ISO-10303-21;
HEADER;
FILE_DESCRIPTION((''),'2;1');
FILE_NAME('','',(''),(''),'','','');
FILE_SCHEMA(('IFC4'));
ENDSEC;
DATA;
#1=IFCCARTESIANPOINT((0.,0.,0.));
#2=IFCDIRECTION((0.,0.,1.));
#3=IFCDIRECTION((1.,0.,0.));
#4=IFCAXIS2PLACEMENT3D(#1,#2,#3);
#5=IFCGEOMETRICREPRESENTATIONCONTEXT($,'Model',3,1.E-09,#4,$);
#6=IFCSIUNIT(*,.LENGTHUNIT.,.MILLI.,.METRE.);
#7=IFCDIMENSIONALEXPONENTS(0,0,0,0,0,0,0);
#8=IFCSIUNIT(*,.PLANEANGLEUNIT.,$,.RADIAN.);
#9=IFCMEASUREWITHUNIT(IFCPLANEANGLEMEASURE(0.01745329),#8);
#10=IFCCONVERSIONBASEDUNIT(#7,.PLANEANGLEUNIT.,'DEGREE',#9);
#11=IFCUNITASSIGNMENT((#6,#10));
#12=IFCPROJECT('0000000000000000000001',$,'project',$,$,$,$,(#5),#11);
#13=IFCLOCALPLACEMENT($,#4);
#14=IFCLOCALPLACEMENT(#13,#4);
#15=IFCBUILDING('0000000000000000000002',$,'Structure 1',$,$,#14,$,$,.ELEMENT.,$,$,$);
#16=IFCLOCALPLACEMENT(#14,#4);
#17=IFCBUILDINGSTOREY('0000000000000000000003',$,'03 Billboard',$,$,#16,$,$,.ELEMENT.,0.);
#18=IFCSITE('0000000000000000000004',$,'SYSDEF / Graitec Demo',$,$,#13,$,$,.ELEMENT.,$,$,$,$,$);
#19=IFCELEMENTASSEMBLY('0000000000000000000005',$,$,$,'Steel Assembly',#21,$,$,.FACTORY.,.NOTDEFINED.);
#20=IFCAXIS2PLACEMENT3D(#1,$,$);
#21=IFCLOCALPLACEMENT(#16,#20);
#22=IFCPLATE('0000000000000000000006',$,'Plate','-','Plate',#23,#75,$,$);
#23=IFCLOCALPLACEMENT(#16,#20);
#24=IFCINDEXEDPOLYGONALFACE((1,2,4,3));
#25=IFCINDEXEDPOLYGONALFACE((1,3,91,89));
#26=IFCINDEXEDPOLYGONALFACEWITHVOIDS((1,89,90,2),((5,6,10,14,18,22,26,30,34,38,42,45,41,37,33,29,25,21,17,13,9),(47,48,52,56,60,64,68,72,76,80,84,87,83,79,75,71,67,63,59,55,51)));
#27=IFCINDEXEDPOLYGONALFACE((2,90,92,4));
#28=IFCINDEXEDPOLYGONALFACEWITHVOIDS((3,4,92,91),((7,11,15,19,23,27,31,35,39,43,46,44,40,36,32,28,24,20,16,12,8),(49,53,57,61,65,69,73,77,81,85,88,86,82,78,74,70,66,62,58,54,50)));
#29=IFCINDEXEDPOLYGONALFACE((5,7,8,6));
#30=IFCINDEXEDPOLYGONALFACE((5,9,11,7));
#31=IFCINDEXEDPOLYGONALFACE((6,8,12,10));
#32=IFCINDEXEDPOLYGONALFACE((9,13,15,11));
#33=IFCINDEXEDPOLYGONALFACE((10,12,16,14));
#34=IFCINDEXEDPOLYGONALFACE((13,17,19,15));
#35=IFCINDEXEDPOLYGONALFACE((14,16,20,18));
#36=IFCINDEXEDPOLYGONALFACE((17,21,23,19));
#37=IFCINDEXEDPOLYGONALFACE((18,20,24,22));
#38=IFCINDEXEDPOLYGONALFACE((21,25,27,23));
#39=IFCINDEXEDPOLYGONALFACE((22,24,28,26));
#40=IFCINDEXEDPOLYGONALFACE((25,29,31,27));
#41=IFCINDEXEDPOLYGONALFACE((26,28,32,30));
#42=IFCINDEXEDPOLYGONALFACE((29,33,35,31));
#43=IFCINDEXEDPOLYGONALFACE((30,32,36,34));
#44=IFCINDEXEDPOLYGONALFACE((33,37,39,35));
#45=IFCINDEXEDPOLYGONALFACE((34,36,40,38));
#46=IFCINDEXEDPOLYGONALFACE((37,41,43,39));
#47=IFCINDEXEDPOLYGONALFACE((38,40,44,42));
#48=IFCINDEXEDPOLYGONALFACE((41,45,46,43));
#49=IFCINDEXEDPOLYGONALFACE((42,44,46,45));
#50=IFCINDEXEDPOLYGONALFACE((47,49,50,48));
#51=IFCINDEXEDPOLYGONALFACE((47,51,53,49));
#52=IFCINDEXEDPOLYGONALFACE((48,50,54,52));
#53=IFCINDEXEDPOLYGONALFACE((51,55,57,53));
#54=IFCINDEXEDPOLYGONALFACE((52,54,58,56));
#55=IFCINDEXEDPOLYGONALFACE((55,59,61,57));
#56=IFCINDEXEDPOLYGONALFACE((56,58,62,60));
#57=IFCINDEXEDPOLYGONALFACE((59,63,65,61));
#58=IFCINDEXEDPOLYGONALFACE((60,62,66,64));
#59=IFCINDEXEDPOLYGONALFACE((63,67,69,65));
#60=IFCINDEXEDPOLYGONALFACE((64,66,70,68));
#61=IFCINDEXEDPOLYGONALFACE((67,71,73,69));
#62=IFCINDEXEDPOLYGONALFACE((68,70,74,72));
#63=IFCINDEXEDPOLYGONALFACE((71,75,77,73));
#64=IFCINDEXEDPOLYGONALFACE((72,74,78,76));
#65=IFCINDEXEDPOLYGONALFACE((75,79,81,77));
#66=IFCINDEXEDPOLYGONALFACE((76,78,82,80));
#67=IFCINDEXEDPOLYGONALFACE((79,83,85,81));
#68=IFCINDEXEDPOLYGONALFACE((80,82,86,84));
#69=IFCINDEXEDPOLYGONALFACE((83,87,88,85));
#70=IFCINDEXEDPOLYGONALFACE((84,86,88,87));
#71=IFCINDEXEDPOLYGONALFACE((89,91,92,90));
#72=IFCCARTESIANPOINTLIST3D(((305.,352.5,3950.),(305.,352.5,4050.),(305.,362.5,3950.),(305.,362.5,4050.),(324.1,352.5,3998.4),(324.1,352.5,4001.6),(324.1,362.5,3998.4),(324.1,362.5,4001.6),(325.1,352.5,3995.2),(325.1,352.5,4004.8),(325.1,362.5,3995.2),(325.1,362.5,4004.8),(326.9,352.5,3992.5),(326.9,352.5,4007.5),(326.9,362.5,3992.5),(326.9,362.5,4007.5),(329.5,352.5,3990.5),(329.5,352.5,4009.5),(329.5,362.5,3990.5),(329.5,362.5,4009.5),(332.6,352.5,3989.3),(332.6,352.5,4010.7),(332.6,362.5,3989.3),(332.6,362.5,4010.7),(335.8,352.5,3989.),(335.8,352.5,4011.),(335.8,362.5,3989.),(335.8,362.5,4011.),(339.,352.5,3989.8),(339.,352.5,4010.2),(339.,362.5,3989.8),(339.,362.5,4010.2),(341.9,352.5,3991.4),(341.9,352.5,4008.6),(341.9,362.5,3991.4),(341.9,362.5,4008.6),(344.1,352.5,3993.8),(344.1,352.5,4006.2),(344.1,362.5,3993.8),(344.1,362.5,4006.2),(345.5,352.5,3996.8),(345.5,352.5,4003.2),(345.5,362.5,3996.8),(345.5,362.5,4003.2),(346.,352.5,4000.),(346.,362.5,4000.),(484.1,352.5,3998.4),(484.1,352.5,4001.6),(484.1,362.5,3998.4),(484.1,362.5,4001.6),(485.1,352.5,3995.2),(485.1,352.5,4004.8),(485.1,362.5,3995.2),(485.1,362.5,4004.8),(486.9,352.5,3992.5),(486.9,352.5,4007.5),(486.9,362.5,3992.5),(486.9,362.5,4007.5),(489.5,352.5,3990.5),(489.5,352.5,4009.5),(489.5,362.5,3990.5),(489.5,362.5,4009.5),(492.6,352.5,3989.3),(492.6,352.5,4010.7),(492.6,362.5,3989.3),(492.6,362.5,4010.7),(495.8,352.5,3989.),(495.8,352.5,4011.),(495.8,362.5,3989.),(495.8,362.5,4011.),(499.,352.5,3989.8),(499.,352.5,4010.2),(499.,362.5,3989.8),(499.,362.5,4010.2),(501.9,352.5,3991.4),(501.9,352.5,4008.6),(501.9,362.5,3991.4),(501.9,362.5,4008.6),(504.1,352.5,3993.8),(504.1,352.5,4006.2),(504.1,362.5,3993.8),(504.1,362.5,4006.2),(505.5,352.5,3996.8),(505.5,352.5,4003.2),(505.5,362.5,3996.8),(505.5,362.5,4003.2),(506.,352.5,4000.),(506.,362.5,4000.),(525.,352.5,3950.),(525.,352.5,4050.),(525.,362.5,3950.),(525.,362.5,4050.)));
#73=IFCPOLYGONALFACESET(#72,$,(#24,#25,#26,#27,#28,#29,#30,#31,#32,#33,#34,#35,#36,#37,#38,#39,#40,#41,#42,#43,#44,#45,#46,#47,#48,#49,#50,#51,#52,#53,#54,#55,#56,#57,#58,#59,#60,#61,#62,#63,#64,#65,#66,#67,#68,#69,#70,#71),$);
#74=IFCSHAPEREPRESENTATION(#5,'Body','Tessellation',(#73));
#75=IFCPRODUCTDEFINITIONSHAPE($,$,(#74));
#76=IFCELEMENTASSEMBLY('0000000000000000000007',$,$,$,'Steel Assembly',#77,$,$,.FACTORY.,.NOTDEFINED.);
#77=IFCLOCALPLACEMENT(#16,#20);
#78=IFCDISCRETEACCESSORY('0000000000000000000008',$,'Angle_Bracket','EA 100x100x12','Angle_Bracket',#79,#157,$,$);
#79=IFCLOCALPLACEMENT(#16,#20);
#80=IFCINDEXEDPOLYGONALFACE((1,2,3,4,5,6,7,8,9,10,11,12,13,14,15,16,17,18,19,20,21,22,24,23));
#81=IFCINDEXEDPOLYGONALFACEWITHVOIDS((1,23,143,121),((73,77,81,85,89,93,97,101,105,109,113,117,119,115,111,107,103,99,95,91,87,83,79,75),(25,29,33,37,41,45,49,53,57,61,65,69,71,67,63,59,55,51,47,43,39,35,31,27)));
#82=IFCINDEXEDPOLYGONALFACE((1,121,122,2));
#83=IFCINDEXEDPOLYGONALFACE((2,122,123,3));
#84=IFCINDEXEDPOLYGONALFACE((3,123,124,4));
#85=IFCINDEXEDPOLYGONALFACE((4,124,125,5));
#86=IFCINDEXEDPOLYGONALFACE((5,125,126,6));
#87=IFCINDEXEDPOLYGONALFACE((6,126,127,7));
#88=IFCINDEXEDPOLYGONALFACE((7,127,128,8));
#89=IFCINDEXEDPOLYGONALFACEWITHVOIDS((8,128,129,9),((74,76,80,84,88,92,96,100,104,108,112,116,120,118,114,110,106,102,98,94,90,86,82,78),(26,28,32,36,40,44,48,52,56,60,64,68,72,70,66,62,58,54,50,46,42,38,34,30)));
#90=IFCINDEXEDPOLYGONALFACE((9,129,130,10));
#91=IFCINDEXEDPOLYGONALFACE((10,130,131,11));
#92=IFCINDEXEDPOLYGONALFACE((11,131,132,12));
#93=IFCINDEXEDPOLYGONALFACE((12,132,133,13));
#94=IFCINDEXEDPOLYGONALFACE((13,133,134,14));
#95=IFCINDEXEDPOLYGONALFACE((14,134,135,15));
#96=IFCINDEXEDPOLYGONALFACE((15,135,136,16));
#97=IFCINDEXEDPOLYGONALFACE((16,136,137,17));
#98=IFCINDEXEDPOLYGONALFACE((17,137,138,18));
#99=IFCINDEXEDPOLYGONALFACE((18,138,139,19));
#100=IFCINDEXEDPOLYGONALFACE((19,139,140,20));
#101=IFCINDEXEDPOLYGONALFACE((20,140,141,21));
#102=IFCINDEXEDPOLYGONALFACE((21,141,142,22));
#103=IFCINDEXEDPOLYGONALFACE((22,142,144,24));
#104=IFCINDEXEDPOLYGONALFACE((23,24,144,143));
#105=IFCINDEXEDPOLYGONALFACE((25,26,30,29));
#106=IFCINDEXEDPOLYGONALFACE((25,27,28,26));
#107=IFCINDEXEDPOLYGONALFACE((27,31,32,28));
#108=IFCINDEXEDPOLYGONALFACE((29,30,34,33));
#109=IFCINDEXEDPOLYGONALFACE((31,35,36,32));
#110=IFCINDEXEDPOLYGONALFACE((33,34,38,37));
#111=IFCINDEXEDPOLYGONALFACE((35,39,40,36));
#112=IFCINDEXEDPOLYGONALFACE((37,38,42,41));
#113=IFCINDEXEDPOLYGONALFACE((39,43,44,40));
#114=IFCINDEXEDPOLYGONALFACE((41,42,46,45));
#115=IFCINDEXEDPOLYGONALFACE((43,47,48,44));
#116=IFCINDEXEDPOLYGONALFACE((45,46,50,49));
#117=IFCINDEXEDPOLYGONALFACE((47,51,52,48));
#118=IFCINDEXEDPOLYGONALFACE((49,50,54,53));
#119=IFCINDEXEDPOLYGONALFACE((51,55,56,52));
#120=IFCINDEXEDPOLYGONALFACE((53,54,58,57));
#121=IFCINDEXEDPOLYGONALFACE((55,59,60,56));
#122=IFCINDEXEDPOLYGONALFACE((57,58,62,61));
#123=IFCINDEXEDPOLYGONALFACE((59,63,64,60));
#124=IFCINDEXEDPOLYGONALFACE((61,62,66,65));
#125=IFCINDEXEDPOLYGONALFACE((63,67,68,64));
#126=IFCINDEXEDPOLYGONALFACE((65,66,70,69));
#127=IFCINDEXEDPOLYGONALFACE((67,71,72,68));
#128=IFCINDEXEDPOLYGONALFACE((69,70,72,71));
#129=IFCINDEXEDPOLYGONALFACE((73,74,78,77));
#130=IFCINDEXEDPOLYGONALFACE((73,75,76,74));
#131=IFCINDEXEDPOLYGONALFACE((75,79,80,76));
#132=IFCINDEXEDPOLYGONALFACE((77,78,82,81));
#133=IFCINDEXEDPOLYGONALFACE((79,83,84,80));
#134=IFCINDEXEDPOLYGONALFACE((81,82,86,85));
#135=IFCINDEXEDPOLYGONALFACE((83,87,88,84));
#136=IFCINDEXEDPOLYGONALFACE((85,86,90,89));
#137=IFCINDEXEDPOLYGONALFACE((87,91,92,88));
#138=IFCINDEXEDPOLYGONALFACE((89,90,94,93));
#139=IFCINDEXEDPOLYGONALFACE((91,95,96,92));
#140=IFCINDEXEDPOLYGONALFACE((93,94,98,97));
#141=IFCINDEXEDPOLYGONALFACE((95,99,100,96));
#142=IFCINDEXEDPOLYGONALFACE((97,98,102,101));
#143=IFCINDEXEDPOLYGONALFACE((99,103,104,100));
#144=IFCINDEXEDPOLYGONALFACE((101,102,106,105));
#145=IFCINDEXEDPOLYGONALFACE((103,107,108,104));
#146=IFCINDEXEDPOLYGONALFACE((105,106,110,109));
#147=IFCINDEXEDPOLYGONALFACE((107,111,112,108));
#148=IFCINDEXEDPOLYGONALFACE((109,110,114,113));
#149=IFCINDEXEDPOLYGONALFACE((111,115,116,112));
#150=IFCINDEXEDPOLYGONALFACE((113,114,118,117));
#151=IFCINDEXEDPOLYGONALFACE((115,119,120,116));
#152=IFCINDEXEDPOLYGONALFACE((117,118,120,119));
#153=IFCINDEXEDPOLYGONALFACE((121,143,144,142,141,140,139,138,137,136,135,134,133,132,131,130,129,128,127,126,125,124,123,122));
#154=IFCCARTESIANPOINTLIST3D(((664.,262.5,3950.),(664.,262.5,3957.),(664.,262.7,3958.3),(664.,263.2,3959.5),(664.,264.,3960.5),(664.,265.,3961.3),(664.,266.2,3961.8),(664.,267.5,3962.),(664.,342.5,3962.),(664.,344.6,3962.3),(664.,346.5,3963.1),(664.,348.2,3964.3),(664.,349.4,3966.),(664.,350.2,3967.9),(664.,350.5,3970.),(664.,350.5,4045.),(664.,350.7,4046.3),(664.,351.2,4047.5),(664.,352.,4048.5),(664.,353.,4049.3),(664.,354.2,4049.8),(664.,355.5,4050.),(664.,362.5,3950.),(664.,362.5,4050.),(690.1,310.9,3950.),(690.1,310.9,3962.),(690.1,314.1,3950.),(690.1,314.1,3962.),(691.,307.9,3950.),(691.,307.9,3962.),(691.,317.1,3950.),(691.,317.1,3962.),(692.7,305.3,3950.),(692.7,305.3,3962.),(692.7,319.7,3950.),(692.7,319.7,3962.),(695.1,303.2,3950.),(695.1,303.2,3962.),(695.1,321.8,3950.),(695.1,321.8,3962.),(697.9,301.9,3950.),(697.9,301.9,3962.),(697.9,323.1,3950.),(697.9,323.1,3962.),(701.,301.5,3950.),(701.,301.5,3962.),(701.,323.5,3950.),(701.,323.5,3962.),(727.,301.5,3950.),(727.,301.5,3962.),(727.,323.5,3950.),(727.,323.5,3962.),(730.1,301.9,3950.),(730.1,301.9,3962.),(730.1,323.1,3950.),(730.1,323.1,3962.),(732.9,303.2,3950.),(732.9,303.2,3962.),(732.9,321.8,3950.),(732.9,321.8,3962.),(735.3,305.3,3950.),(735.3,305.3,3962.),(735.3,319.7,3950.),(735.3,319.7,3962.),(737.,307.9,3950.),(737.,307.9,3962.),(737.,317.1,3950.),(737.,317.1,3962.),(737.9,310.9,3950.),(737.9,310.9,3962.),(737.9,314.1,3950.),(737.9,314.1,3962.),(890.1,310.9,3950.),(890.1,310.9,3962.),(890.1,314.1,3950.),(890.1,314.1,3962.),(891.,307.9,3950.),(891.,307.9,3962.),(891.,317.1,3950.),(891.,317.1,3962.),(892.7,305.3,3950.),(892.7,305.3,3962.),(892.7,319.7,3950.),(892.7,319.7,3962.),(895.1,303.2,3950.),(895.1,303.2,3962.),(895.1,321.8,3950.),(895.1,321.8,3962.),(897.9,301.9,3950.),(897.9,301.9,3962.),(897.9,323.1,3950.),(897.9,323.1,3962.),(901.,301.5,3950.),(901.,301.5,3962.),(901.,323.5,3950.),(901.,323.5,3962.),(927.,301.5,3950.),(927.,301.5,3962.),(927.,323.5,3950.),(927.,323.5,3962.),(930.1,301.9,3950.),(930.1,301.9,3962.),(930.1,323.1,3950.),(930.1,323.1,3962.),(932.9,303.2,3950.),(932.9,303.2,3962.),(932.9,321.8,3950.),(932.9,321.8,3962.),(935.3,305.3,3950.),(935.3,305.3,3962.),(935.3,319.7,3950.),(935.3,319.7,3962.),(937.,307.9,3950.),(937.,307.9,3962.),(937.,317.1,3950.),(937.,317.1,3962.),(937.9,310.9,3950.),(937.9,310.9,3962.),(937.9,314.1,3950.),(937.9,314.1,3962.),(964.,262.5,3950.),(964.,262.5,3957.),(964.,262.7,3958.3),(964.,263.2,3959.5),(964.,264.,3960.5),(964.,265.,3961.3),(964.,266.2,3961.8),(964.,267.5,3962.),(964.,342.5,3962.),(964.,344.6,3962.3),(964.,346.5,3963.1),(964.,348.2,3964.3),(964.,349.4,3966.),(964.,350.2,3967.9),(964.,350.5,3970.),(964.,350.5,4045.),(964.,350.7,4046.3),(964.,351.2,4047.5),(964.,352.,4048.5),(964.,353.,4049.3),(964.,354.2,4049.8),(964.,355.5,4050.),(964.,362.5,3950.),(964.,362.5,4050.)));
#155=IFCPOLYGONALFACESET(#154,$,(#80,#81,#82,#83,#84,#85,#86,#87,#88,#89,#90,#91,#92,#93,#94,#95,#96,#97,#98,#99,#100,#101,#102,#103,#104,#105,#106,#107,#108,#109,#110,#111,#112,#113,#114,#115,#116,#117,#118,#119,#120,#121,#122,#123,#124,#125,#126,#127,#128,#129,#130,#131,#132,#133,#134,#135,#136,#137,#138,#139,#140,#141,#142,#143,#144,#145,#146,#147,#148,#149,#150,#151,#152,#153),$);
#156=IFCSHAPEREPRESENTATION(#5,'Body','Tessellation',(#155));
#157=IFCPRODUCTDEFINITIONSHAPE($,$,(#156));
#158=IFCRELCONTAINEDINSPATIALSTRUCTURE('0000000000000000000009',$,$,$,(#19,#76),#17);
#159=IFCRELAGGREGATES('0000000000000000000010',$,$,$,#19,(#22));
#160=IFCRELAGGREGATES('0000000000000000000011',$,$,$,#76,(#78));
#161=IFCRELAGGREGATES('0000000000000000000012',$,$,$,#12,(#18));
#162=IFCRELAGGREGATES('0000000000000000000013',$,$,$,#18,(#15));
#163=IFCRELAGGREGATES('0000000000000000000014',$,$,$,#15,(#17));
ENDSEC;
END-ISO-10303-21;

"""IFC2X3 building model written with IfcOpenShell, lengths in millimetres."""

from ifc_helpers import new_model, entity, si_unit, converted_unit, point, frame, frame_2d, origin, origin_with_axes, place, context, project, spatial, polyline, circle_curve, line_curve, trimmed, segment, composite_curve, circle, l_section, outline, extrude, element, aggregate, save


model = new_model("IFC2X3")

# Units and contexts
model_context = context("Model", 3, precision=1e-09, world=origin_with_axes())
ifc_project = project(units=[si_unit("LENGTHUNIT", "METRE", prefix="MILLI"), converted_unit("PLANEANGLEUNIT", "DEGREE", entity("IfcPlaneAngleMeasure", 0.01745329), si_unit("PLANEANGLEUNIT", "RADIAN"), dimensions=[0, 0, 0, 0, 0, 0, 0])], contexts=[model_context])

# Site, building, storey
site_placement = place(None, origin_with_axes())
site = spatial("IfcSite", under=ifc_project, at=site_placement, Name="SYSDEF / Graitec Demo", CompositionType="ELEMENT")
building_placement = place(site_placement, origin_with_axes())
building = spatial("IfcBuilding", under=site, at=building_placement, Name="Structure 1", CompositionType="ELEMENT")
storey_placement = place(building_placement, origin_with_axes())
storey = spatial("IfcBuildingStorey", under=building, at=storey_placement, Name="03 Billboard", CompositionType="ELEMENT", Elevation=0.0)

# Element assembly, plate, openings
assembly_1_placement = place(None, frame((415.0, 362.5, 4000.0), z_axis=(0.0, -1.0, 0.0), x_axis=(1.0, 0.0, 0.0)))
assembly_1 = element("IfcElementAssembly", 1, at=assembly_1_placement, inside=storey, ObjectType="Steel Assembly", AssemblyPlace="FACTORY", PredefinedType="NOTDEFINED")
plate_placement = place(assembly_1_placement, origin_with_axes())
plate = element("IfcPlate", 2, at=plate_placement, Name="Plate", Description="-", ObjectType="Plate", context=model_context, shape_type="SweptSolid", body=[
    extrude(outline(polyline([(-110.0, -50.0), (110.0, -50.0), (110.0, 50.0), (-110.0, 50.0), (-110.0, -50.0)])), origin_with_axes(), (0.0, 0.0, 1.0), 10.0),
])
opening_1_placement = place(plate_placement, frame((69.0, 0.0, 10.5), z_axis=(0.0, 0.0, 1.0), x_axis=(1.0, 0.0, 0.0)))
element("IfcOpeningElement", 3, at=opening_1_placement, cuts=plate, ObjectType="Opening", context=model_context, shape_type="SweptSolid", body=[
    extrude(circle(Radius=11.0, at=frame_2d((11.0, 0.0), x_axis=(1.0, 0.0))), origin(), (0.0, 0.0, -1.0), 11.0),
])
opening_2_placement = place(plate_placement, frame((-91.0, 0.0, 10.5), z_axis=(0.0, 0.0, 1.0), x_axis=(1.0, 0.0, 0.0)))
element("IfcOpeningElement", 4, at=opening_2_placement, cuts=plate, ObjectType="Opening", context=model_context, shape_type="SweptSolid", body=[
    extrude(circle(Radius=11.0, at=frame_2d((11.0, 0.0), x_axis=(1.0, 0.0))), origin(), (0.0, 0.0, -1.0), 11.0),
])
aggregate(assembly_1, [plate])

# Element assembly, discrete accessory, openings
assembly_2_placement = place(None, frame((-4239.1, -387.5, 4000.0), z_axis=(-1.0, 0.0, 0.0), x_axis=(0.0, 0.0, 1.0)))
assembly_2 = element("IfcElementAssembly", 5, at=assembly_2_placement, inside=storey, ObjectType="Steel Assembly", AssemblyPlace="FACTORY", PredefinedType="NOTDEFINED")
discrete_accessory_1_placement = place(assembly_2_placement, frame((-20.8, 720.8, -4903.1), z_axis=(0.0, 0.0, 1.0), x_axis=(0.0, -1.0, 0.0)))
discrete_accessory_1 = element("IfcDiscreteAccessory", 6, at=discrete_accessory_1_placement, Name="Angle_Bracket", Description="EA 100x100x12", ObjectType="Angle_Bracket", context=model_context, shape_type="SweptSolid", body=[
    extrude(l_section(Depth=100.0, Width=100.0, Thickness=12.0, FilletRadius=8.0, EdgeRadius=5.0, at=frame_2d((20.8, 20.8))), origin(), (0.0, 0.0, -1.0), 300.0),
])
opening_3_placement = place(discrete_accessory_1_placement, frame((20.8, -16.7, -150.0), z_axis=(0.0, -1.0, 0.0), x_axis=(0.0, 0.0, 1.0)))
element("IfcOpeningElement", 7, at=opening_3_placement, cuts=discrete_accessory_1, ObjectType="Opening", context=model_context, shape_type="SweptSolid", body=[
    extrude(outline(composite_curve([segment(trimmed(line_curve((87.0, -11.0), (1.0, 0.0), 26.0), [point((87.0, -11.0))], [point((113.0, -11.0))], True, "CARTESIAN"), True, "CONTINUOUS"), segment(trimmed(circle_curve(frame_2d((113.0, 0.0), x_axis=(1.0, 0.0)), 11.0), [point((113.0, -11.0))], [point((113.0, 11.0))], True, "CARTESIAN"), True, "CONTINUOUS"), segment(trimmed(line_curve((113.0, 11.0), (-1.0, 0.0), 26.0), [point((113.0, 11.0))], [point((87.0, 11.0))], True, "CARTESIAN"), True, "CONTINUOUS"), segment(trimmed(circle_curve(frame_2d((87.0, 0.0), x_axis=(1.0, 0.0)), 11.0), [point((87.0, 11.0))], [point((87.0, -11.0))], True, "CARTESIAN"), True, "CONTINUOUS")], self_intersect=False)), origin(), (0.0, 0.0, 1.0), 13.0),
])
opening_4_placement = place(discrete_accessory_1_placement, frame((20.8, -16.7, -150.0), z_axis=(0.0, -1.0, 0.0), x_axis=(0.0, 0.0, 1.0)))
element("IfcOpeningElement", 8, at=opening_4_placement, cuts=discrete_accessory_1, ObjectType="Opening", context=model_context, shape_type="SweptSolid", body=[
    extrude(outline(composite_curve([segment(trimmed(line_curve((-113.0, -11.0), (1.0, 0.0), 26.0), [point((-113.0, -11.0))], [point((-87.0, -11.0))], True, "CARTESIAN"), True, "CONTINUOUS"), segment(trimmed(circle_curve(frame_2d((-87.0, 0.0), x_axis=(1.0, 0.0)), 11.0), [point((-87.0, -11.0))], [point((-87.0, 11.0))], True, "CARTESIAN"), True, "CONTINUOUS"), segment(trimmed(line_curve((-87.0, 11.0), (-1.0, 0.0), 26.0), [point((-87.0, 11.0))], [point((-113.0, 11.0))], True, "CARTESIAN"), True, "CONTINUOUS"), segment(trimmed(circle_curve(frame_2d((-113.0, 0.0), x_axis=(1.0, 0.0)), 11.0), [point((-113.0, 11.0))], [point((-113.0, -11.0))], True, "CARTESIAN"), True, "CONTINUOUS")], self_intersect=False)), origin(), (0.0, 0.0, 1.0), 13.0),
])
aggregate(assembly_2, [discrete_accessory_1])

save(model, "model.ifc")
